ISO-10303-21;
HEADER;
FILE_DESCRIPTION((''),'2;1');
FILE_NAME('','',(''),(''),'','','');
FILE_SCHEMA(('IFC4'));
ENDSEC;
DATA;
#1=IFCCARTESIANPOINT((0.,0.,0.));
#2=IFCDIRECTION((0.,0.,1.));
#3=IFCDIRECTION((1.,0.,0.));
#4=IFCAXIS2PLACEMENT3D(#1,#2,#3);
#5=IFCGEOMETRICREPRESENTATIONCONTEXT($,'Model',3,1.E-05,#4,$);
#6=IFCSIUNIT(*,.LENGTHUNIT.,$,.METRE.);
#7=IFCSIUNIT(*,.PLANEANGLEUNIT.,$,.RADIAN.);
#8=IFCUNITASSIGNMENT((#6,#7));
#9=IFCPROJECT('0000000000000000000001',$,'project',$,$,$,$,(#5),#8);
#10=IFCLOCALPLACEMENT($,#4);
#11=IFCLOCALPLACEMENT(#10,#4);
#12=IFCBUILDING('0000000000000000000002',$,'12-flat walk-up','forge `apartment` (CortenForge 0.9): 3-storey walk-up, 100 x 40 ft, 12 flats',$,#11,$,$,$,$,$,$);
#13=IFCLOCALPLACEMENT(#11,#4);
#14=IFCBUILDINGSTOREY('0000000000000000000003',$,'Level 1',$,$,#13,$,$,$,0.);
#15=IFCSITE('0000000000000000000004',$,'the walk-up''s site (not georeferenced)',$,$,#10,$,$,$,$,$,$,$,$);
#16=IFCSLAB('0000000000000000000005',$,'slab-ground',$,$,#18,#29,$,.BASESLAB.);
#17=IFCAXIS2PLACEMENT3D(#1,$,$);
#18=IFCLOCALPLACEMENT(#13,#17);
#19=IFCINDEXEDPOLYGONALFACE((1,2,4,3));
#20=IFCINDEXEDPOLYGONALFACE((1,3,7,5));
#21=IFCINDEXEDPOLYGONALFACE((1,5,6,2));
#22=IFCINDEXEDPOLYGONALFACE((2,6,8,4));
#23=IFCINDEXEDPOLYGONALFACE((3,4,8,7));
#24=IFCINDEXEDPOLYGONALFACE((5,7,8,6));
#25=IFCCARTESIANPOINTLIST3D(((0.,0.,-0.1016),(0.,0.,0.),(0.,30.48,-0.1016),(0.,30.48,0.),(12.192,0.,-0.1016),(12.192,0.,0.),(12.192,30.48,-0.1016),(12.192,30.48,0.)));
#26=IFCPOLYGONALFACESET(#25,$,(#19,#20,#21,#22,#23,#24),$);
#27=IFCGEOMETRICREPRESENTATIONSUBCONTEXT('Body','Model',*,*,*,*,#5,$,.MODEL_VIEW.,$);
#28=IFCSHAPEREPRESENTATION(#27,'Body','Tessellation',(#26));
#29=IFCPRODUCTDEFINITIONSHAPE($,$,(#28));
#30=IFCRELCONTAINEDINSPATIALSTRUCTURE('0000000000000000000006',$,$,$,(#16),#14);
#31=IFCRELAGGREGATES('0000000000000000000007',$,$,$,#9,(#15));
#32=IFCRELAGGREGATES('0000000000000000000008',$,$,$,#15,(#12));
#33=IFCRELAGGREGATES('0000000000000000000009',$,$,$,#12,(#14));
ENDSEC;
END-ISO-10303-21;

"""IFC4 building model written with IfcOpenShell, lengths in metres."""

from ifc_helpers import new_model, si_unit, frame, frame_2d, origin, origin_with_axes, place, context, subcontext, project, spatial, rectangle, extrude, element, save


model = new_model("IFC4")

# Units and contexts
model_context = context("Model", 3, precision=1e-05, world=origin_with_axes())
body_context = subcontext(model_context, "Body", "Model", "MODEL_VIEW")
ifc_project = project(units=[si_unit("LENGTHUNIT", "METRE"), si_unit("PLANEANGLEUNIT", "RADIAN")], contexts=[model_context])

# Site, building, storey
site_placement = place(None, origin_with_axes())
site = spatial("IfcSite", under=ifc_project, at=site_placement, Name="the walk-up's site (not georeferenced)")
building_placement = place(site_placement, origin_with_axes())
building = spatial("IfcBuilding", under=site, at=building_placement, Name="12-flat walk-up", Description="forge `apartment` (CortenForge 0.9): 3-storey walk-up, 100 x 40 ft, 12 flats")
storey_placement = place(building_placement, origin_with_axes())
storey = spatial("IfcBuildingStorey", under=building, at=storey_placement, Name="Level 1", Elevation=0.0)

# Slab
slab_placement = place(storey_placement, frame((0.0, 0.0, -0.1016), z_axis=(0.0, 0.0, 1.0), x_axis=(1.0, 0.0, 0.0)))
element("IfcSlab", 1, at=slab_placement, inside=storey, Name="slab-ground", PredefinedType="BASESLAB", context=body_context, shape_type="SweptSolid", body=[
    extrude(rectangle(XDim=12.192, YDim=30.48, at=frame_2d((6.096, 15.24))), origin(), (0.0, 0.0, 1.0), 0.1016),
])

save(model, "model.ifc")
